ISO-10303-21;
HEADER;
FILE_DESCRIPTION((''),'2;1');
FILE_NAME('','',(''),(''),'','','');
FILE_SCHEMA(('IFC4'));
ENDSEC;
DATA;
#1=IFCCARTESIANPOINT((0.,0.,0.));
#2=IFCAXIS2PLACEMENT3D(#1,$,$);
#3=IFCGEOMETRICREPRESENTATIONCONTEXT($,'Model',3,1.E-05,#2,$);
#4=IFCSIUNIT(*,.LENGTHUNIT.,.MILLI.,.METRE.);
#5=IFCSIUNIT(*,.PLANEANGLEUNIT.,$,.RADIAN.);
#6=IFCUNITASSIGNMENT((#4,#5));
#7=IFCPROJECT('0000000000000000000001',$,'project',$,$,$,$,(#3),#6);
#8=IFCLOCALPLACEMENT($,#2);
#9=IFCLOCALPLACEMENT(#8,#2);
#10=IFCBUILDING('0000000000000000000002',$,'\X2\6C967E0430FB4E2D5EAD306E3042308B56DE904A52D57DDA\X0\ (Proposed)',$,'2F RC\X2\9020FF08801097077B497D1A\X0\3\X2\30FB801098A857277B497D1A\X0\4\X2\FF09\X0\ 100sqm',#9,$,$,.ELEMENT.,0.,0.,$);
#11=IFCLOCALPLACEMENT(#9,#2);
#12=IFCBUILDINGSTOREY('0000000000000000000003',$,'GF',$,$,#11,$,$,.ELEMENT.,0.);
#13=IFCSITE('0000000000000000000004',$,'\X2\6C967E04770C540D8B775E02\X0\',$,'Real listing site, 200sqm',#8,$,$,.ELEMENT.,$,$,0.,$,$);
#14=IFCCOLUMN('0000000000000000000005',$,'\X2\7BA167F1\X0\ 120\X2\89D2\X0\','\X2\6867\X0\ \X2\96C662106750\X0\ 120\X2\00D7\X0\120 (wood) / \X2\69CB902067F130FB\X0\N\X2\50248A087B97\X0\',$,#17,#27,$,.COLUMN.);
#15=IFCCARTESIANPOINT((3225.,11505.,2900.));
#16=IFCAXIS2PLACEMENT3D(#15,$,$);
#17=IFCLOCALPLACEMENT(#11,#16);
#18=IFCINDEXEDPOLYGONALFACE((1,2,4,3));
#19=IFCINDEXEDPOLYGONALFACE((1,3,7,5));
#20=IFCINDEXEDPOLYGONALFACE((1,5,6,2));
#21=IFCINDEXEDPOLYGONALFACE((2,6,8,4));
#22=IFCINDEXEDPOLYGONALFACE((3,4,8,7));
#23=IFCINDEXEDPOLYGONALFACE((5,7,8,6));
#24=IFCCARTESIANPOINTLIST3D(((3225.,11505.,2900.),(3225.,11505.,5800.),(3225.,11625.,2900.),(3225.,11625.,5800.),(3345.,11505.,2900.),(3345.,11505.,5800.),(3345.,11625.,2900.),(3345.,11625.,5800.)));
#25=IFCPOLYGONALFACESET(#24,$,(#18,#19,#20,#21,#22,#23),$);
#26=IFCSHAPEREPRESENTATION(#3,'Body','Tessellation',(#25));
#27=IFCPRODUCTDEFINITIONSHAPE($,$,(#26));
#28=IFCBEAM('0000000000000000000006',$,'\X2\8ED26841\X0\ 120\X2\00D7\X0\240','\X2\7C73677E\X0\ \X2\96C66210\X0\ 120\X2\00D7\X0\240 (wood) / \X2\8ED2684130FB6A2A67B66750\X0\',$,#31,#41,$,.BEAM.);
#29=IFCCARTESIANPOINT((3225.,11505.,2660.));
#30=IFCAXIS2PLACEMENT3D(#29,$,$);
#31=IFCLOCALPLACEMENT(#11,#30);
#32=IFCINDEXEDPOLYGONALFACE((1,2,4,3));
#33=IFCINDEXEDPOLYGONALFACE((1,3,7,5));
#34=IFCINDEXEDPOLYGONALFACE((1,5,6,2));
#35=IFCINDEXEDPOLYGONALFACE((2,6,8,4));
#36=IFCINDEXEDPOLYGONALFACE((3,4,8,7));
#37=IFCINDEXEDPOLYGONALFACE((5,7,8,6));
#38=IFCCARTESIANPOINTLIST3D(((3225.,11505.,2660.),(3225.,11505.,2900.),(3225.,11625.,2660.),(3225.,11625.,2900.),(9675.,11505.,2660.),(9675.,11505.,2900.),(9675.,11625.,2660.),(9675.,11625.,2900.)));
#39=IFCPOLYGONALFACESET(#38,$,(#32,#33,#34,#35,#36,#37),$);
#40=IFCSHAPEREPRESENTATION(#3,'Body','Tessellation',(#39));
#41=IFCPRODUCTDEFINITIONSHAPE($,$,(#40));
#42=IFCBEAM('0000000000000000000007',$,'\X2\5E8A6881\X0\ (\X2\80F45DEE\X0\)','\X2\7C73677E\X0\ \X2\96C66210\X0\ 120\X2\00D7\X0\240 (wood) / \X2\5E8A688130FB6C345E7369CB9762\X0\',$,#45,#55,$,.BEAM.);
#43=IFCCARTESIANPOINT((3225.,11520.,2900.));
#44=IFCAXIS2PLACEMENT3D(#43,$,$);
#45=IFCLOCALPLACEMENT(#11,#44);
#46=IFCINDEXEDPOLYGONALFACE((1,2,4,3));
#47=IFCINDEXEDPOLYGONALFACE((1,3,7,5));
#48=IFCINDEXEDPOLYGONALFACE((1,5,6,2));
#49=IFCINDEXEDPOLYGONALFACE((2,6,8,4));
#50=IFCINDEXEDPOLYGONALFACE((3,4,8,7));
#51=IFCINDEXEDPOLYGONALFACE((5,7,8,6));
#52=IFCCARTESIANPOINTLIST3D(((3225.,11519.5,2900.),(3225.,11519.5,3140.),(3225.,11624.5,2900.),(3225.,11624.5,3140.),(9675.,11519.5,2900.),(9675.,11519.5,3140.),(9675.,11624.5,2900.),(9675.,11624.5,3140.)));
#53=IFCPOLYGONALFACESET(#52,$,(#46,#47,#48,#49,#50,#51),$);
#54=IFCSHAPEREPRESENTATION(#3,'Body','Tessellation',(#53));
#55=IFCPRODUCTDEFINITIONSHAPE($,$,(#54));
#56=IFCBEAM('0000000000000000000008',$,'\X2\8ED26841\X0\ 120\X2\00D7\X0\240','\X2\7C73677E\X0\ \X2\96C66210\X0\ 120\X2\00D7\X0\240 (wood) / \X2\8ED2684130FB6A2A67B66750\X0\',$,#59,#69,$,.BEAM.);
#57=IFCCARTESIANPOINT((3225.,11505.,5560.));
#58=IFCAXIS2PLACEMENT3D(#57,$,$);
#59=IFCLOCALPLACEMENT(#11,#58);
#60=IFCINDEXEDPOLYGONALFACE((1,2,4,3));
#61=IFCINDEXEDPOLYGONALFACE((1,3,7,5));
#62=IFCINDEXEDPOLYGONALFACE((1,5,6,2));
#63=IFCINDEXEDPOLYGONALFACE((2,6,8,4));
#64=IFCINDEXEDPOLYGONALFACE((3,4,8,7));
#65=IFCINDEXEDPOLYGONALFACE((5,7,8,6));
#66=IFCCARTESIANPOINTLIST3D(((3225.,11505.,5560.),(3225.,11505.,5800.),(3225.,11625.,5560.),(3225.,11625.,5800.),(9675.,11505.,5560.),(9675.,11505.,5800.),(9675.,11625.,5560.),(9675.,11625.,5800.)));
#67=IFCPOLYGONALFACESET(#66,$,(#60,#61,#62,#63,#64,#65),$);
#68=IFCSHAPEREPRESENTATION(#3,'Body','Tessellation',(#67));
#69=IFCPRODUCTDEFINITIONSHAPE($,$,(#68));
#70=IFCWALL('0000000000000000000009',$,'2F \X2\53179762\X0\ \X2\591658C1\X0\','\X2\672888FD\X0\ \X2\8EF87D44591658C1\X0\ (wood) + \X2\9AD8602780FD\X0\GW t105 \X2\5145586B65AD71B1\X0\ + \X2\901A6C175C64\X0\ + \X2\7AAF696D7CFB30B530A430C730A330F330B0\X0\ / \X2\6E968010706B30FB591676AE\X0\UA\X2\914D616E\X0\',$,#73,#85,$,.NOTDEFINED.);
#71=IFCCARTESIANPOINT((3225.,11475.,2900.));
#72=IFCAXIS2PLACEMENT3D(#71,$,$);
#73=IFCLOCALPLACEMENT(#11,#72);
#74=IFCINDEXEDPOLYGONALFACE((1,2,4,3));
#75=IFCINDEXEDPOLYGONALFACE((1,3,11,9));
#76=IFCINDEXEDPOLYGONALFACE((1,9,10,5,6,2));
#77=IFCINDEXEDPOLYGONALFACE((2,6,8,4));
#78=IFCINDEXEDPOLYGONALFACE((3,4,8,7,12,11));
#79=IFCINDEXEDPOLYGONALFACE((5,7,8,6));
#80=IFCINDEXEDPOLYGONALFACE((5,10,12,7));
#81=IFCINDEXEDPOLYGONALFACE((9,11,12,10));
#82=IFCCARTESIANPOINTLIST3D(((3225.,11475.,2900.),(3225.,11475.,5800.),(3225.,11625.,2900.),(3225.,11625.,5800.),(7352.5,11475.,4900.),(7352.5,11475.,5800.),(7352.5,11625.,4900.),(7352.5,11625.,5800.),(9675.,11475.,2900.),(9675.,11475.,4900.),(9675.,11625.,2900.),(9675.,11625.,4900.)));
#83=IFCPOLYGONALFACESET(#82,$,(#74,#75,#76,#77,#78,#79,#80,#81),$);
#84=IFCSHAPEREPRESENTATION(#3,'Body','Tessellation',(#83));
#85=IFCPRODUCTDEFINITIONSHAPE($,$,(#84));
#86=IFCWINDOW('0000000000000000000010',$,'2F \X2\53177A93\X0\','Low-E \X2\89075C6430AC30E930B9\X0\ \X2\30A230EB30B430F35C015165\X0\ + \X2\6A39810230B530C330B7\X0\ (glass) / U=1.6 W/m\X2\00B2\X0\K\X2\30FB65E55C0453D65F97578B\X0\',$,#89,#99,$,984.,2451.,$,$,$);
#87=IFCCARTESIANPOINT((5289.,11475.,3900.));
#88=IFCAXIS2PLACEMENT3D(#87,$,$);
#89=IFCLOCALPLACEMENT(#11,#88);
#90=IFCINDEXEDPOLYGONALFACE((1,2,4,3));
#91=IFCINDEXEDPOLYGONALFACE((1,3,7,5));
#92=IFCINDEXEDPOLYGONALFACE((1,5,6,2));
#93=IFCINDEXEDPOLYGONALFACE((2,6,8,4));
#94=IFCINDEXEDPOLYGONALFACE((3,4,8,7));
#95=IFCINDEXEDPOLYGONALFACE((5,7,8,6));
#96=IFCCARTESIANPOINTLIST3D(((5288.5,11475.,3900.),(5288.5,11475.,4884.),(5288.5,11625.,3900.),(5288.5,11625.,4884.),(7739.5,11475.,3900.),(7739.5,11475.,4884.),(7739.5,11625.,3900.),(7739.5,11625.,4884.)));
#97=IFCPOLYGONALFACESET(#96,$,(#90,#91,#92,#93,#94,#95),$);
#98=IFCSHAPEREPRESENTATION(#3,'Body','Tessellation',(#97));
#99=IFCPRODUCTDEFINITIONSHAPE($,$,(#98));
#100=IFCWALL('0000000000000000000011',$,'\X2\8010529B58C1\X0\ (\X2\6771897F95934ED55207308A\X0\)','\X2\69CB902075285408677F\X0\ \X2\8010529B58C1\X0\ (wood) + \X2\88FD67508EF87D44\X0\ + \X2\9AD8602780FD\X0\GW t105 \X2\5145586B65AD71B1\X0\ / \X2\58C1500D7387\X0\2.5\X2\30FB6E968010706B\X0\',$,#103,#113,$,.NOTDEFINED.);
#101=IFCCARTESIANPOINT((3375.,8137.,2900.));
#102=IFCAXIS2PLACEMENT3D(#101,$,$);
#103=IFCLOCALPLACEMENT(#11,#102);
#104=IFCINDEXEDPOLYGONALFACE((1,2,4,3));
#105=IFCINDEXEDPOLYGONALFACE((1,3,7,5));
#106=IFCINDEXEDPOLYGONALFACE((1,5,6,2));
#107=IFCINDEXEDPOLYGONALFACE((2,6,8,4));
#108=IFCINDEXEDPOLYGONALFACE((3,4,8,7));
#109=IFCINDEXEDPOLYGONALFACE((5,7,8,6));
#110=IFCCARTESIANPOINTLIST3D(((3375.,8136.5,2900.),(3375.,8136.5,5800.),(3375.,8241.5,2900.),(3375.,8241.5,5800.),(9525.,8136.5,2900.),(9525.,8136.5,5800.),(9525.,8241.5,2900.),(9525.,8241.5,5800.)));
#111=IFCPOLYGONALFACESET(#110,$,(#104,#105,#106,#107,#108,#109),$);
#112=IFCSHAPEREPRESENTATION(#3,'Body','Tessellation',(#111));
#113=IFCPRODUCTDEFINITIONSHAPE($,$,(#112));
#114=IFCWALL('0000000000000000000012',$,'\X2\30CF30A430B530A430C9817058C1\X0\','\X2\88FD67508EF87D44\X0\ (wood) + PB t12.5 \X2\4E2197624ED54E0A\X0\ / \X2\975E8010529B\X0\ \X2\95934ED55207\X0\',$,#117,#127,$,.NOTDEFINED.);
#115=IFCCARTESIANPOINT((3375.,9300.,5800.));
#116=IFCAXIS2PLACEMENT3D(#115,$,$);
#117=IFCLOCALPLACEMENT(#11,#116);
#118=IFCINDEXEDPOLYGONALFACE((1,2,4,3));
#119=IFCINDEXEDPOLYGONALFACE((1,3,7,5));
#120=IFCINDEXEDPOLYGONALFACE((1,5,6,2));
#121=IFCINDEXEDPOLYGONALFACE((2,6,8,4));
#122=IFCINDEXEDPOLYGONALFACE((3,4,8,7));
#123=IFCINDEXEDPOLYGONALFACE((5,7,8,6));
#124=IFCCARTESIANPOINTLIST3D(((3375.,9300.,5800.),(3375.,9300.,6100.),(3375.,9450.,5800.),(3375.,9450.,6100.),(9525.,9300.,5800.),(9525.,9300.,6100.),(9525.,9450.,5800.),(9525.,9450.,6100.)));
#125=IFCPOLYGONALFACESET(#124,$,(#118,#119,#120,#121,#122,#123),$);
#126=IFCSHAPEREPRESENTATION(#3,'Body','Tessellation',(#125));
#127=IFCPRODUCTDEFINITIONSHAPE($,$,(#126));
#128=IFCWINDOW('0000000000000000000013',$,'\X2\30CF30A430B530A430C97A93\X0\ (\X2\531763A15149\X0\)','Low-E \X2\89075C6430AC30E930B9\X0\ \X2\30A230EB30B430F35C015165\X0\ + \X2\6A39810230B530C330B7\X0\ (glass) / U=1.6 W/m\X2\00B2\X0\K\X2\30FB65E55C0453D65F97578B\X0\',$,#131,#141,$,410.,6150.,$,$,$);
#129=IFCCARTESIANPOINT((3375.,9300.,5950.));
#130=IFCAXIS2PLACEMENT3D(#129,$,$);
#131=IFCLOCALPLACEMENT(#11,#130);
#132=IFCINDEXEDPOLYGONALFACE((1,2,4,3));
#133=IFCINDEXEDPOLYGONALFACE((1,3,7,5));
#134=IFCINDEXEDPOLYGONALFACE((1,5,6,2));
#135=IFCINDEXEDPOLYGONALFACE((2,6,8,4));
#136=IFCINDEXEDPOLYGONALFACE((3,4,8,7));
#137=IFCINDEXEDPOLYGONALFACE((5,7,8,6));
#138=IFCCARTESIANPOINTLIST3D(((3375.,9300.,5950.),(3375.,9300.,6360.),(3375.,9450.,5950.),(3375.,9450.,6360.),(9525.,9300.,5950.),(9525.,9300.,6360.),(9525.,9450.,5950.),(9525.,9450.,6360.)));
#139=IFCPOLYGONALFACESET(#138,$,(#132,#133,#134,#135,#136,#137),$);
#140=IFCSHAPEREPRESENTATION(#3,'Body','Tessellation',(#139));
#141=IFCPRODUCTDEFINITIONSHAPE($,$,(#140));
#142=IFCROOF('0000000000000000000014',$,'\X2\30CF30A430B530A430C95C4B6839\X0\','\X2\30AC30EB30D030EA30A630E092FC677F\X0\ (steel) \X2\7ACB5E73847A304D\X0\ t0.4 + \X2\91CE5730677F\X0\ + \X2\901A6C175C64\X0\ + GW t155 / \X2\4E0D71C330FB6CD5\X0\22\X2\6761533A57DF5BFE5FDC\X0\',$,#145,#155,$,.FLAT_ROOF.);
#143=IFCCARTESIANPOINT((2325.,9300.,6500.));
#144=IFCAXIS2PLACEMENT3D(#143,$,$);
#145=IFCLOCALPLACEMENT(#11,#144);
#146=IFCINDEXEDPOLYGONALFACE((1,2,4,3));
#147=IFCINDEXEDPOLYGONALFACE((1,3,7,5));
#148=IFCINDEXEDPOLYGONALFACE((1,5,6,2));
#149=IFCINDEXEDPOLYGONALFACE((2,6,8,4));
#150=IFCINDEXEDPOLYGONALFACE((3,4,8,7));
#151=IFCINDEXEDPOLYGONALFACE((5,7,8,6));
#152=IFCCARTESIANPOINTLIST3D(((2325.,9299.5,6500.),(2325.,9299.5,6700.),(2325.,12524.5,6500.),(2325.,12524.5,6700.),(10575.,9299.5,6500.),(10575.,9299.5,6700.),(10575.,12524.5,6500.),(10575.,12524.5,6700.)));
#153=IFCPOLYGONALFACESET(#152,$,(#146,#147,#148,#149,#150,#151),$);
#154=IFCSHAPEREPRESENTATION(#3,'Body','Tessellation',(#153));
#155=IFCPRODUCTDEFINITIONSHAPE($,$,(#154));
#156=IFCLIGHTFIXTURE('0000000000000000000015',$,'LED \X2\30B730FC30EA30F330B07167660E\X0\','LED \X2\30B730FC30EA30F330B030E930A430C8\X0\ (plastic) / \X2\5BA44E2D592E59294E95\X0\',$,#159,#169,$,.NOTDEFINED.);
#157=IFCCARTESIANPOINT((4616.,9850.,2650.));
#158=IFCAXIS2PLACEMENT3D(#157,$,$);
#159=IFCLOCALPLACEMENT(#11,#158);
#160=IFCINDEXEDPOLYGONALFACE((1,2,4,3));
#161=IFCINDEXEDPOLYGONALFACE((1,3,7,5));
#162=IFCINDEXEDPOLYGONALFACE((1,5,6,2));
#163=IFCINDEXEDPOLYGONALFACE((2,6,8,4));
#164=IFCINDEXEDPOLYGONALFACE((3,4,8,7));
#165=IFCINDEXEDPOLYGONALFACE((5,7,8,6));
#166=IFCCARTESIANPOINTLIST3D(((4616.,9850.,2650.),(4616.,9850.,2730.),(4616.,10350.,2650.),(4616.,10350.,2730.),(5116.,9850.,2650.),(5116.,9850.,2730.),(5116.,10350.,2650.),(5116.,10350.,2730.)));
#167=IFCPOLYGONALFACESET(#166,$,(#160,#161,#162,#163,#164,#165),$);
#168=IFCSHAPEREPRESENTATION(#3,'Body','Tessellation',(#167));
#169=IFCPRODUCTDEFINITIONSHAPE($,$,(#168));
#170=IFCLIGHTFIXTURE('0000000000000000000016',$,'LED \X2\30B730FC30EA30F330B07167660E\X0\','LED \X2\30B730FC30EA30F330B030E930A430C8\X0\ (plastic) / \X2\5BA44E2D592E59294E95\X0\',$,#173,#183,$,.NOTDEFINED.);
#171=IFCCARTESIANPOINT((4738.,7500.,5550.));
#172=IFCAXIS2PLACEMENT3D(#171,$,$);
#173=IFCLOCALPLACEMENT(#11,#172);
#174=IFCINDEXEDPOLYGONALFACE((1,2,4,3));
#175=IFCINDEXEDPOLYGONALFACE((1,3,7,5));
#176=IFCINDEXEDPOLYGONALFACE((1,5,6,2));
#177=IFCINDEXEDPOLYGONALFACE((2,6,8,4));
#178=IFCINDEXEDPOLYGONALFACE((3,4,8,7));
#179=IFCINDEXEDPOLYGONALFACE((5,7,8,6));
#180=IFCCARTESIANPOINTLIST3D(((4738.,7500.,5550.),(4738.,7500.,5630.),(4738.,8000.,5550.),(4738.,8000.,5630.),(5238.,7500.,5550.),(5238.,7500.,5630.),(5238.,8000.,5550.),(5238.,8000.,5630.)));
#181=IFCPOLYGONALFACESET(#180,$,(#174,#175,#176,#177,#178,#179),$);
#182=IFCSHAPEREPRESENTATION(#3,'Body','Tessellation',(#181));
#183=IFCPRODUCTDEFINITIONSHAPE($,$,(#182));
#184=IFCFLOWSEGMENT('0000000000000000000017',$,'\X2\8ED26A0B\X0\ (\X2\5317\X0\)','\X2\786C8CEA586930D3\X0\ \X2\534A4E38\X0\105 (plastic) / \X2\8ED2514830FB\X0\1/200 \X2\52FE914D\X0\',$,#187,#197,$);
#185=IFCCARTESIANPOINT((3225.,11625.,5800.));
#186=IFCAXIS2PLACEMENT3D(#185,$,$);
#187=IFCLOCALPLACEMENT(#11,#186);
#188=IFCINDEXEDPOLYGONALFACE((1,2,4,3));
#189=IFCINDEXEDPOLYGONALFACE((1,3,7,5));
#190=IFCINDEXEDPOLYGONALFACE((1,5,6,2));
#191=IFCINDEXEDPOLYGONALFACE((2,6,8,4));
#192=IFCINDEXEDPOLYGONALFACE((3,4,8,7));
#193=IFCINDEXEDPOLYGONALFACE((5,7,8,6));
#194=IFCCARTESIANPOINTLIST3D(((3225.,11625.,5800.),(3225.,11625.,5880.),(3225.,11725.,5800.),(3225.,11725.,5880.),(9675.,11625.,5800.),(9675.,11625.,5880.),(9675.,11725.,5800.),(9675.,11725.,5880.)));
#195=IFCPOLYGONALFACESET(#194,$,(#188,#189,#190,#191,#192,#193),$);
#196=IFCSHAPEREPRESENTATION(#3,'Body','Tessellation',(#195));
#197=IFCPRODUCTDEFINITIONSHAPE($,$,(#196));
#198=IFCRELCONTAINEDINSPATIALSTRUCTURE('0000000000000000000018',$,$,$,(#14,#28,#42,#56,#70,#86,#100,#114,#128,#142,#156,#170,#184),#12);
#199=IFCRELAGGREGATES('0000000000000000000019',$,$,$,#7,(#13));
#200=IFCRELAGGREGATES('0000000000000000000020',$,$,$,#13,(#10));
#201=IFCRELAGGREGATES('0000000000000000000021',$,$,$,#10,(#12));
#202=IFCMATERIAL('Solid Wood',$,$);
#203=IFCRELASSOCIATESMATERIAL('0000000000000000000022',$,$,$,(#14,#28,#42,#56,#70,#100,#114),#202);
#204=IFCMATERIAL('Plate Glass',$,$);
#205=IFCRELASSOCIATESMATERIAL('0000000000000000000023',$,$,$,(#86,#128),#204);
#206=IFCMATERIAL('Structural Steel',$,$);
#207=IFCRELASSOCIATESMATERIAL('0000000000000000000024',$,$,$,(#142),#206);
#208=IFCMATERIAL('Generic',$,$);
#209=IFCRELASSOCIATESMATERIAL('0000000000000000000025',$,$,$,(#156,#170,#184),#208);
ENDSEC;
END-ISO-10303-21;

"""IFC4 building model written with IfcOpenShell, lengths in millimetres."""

from ifc_helpers import new_model, si_unit, frame, frame_2d, origin, place, context, project, spatial, rectangle, extrude, material, element, fill, save


model = new_model("IFC4")

# Units and contexts
model_context = context("Model", 3, precision=1e-05, world=origin())
ifc_project = project(units=[si_unit("LENGTHUNIT", "METRE", prefix="MILLI"), si_unit("PLANEANGLEUNIT", "RADIAN")], contexts=[model_context])

# Site, building, storey
site_placement = place(None, origin())
site = spatial("IfcSite", under=ifc_project, at=site_placement, Name="沖縄県名護市", ObjectType="Real listing site, 200sqm", CompositionType="ELEMENT", RefElevation=0.0)
building_placement = place(site_placement, origin())
building = spatial("IfcBuilding", under=site, at=building_placement, Name="沖縄・中庭のある回遊動線 (Proposed)", ObjectType="2F RC造（耐震等級3・耐風圧等級4） 100sqm", CompositionType="ELEMENT", ElevationOfRefHeight=0.0, ElevationOfTerrain=0.0)
storey_placement = place(building_placement, origin())
storey = spatial("IfcBuildingStorey", under=building, at=storey_placement, Name="GF", CompositionType="ELEMENT", Elevation=0.0)

# Column
ifc_material_1 = material(Name="Solid Wood")
column_1_placement = place(storey_placement, frame((3225.0, 11505.0, 2900.0)))
element("IfcColumn", 1, at=column_1_placement, inside=storey, material=ifc_material_1, Name="管柱 120角", Description="桧 集成材 120×120 (wood) / 構造柱・N値計算", PredefinedType="COLUMN", context=model_context, shape_type="SweptSolid", body=[
    extrude(rectangle(XDim=120.0, YDim=120.0, at=frame_2d((60.0, 60.0))), frame((3225.0, 11505.0, 2900.0)), (0.0, 0.0, 1.0), 2900.0),
])

# Beams
beam_1_placement = place(storey_placement, frame((3225.0, 11505.0, 2660.0)))
element("IfcBeam", 2, at=beam_1_placement, inside=storey, material=ifc_material_1, Name="軒桁 120×240", Description="米松 集成 120×240 (wood) / 軒桁・横架材", PredefinedType="BEAM", context=model_context, shape_type="SweptSolid", body=[
    extrude(rectangle(XDim=6450.0, YDim=120.0, at=frame_2d((3225.0, 60.0))), frame((3225.0, 11505.0, 2660.0)), (0.0, 0.0, 1.0), 240.0),
])
beam_2_placement = place(storey_placement, frame((3225.0, 11520.0, 2900.0)))
element("IfcBeam", 3, at=beam_2_placement, inside=storey, material=ifc_material_1, Name="床梁 (胴差)", Description="米松 集成 120×240 (wood) / 床梁・水平構面", PredefinedType="BEAM", context=model_context, shape_type="SweptSolid", body=[
    extrude(rectangle(XDim=6450.0, YDim=105.0, at=frame_2d((3225.0, 52.0))), frame((3225.0, 11520.0, 2900.0)), (0.0, 0.0, 1.0), 240.0),
])
beam_3_placement = place(storey_placement, frame((3225.0, 11505.0, 5560.0)))
element("IfcBeam", 4, at=beam_3_placement, inside=storey, material=ifc_material_1, Name="軒桁 120×240", Description="米松 集成 120×240 (wood) / 軒桁・横架材", PredefinedType="BEAM", context=model_context, shape_type="SweptSolid", body=[
    extrude(rectangle(XDim=6450.0, YDim=120.0, at=frame_2d((3225.0, 60.0))), frame((3225.0, 11505.0, 5560.0)), (0.0, 0.0, 1.0), 240.0),
])

# Wall, opening, window
wall_1_placement = place(storey_placement, frame((3225.0, 11475.0, 2900.0)))
wall_1 = element("IfcWall", 5, at=wall_1_placement, inside=storey, material=ifc_material_1, Name="2F 北面 外壁", Description="木製 軸組外壁 (wood) + 高性能GW t105 充填断熱 + 通気層 + 窯業系サイディング / 準耐火・外皮UA配慮", PredefinedType="NOTDEFINED", context=model_context, shape_type="SweptSolid", body=[
    extrude(rectangle(XDim=6450.0, YDim=150.0, at=frame_2d((3225.0, 75.0))), frame((3225.0, 11475.0, 2900.0)), (0.0, 0.0, 1.0), 2900.0),
])
opening_1_placement = place(storey_placement, frame((5289.0, 11475.0, 3900.0)))
opening_1 = element("IfcOpeningElement", 6, at=opening_1_placement, cuts=wall_1, PredefinedType="NOTDEFINED", context=model_context, shape_type="SweptSolid", body=[
    extrude(rectangle(XDim=2451.0, YDim=150.0, at=frame_2d((1225.0, 75.0))), frame((5289.0, 11475.0, 3900.0)), (0.0, 0.0, 1.0), 984.0),
])
ifc_material_2 = material(Name="Plate Glass")
window_1_placement = place(storey_placement, frame((5289.0, 11475.0, 3900.0)))
window_1 = element("IfcWindow", 7, at=window_1_placement, inside=storey, material=ifc_material_2, Name="2F 北窓", Description="Low-E 複層ガラス アルゴン封入 + 樹脂サッシ (glass) / U=1.6 W/m²K・日射取得型", OverallHeight=984.0, OverallWidth=2451.0, context=model_context, shape_type="SweptSolid", body=[
    extrude(rectangle(XDim=2451.0, YDim=150.0, at=frame_2d((1225.0, 75.0))), frame((5289.0, 11475.0, 3900.0)), (0.0, 0.0, 1.0), 984.0),
])
fill(opening_1, window_1)

# Wall
wall_2_placement = place(storey_placement, frame((3375.0, 8137.0, 2900.0)))
element("IfcWall", 8, at=wall_2_placement, inside=storey, material=ifc_material_1, Name="耐力壁 (東西間仕切り)", Description="構造用合板 耐力壁 (wood) + 製材軸組 + 高性能GW t105 充填断熱 / 壁倍率2.5・準耐火", PredefinedType="NOTDEFINED", context=model_context, shape_type="SweptSolid", body=[
    extrude(rectangle(XDim=6150.0, YDim=105.0, at=frame_2d((3075.0, 52.0))), frame((3375.0, 8137.0, 2900.0)), (0.0, 0.0, 1.0), 2900.0),
])

# Wall, opening, window
wall_3_placement = place(storey_placement, frame((3375.0, 9300.0, 5800.0)))
wall_3 = element("IfcWall", 9, at=wall_3_placement, inside=storey, material=ifc_material_1, Name="ハイサイド腰壁", Description="製材軸組 (wood) + PB t12.5 両面仕上 / 非耐力 間仕切", PredefinedType="NOTDEFINED", context=model_context, shape_type="SweptSolid", body=[
    extrude(rectangle(XDim=6150.0, YDim=150.0, at=frame_2d((3075.0, 75.0))), frame((3375.0, 9300.0, 5800.0)), (0.0, 0.0, 1.0), 700.0),
])
opening_2_placement = place(storey_placement, frame((3375.0, 9300.0, 5950.0)))
opening_2 = element("IfcOpeningElement", 10, at=opening_2_placement, cuts=wall_3, PredefinedType="NOTDEFINED", context=model_context, shape_type="SweptSolid", body=[
    extrude(rectangle(XDim=6150.0, YDim=150.0, at=frame_2d((3075.0, 75.0))), frame((3375.0, 9300.0, 5950.0)), (0.0, 0.0, 1.0), 410.0),
])
window_2_placement = place(storey_placement, frame((3375.0, 9300.0, 5950.0)))
window_2 = element("IfcWindow", 11, at=window_2_placement, inside=storey, material=ifc_material_2, Name="ハイサイド窓 (北採光)", Description="Low-E 複層ガラス アルゴン封入 + 樹脂サッシ (glass) / U=1.6 W/m²K・日射取得型", OverallHeight=410.0, OverallWidth=6150.0, context=model_context, shape_type="SweptSolid", body=[
    extrude(rectangle(XDim=6150.0, YDim=150.0, at=frame_2d((3075.0, 75.0))), frame((3375.0, 9300.0, 5950.0)), (0.0, 0.0, 1.0), 410.0),
])
fill(opening_2, window_2)

# Roof
ifc_material_3 = material(Name="Structural Steel")
roof_placement = place(storey_placement, frame((2325.0, 9300.0, 6500.0)))
element("IfcRoof", 12, at=roof_placement, inside=storey, material=ifc_material_3, Name="ハイサイド屋根", Description="ガルバリウム鋼板 (steel) 立平葺き t0.4 + 野地板 + 通気層 + GW t155 / 不燃・法22条区域対応", PredefinedType="FLAT_ROOF", context=model_context, shape_type="SweptSolid", body=[
    extrude(rectangle(XDim=8250.0, YDim=3225.0, at=frame_2d((4125.0, 1612.0))), frame((2325.0, 9300.0, 6500.0)), (0.0, 0.0, 1.0), 200.0),
])

# Light fixtures
ifc_material_4 = material(Name="Generic")
light_fixture_1_placement = place(storey_placement, frame((4616.0, 9850.0, 2650.0)))
element("IfcLightFixture", 13, at=light_fixture_1_placement, inside=storey, material=ifc_material_4, Name="LED シーリング照明", Description="LED シーリングライト (plastic) / 室中央天井", PredefinedType="NOTDEFINED", context=model_context, shape_type="SweptSolid", body=[
    extrude(rectangle(XDim=500.0, YDim=500.0, at=frame_2d((250.0, 250.0))), frame((4616.0, 9850.0, 2650.0)), (0.0, 0.0, 1.0), 80.0),
])
light_fixture_2_placement = place(storey_placement, frame((4738.0, 7500.0, 5550.0)))
element("IfcLightFixture", 14, at=light_fixture_2_placement, inside=storey, material=ifc_material_4, Name="LED シーリング照明", Description="LED シーリングライト (plastic) / 室中央天井", PredefinedType="NOTDEFINED", context=model_context, shape_type="SweptSolid", body=[
    extrude(rectangle(XDim=500.0, YDim=500.0, at=frame_2d((250.0, 250.0))), frame((4738.0, 7500.0, 5550.0)), (0.0, 0.0, 1.0), 80.0),
])

# Flow segment
flow_segment_placement = place(storey_placement, frame((3225.0, 11625.0, 5800.0)))
element("IfcFlowSegment", 15, at=flow_segment_placement, inside=storey, material=ifc_material_4, Name="軒樋 (北)", Description="硬質塩ビ 半丸105 (plastic) / 軒先・1/200 勾配", context=model_context, shape_type="SweptSolid", body=[
    extrude(rectangle(XDim=6450.0, YDim=100.0, at=frame_2d((3225.0, 50.0))), frame((3225.0, 11625.0, 5800.0)), (0.0, 0.0, 1.0), 80.0),
])

save(model, "model.ifc")
